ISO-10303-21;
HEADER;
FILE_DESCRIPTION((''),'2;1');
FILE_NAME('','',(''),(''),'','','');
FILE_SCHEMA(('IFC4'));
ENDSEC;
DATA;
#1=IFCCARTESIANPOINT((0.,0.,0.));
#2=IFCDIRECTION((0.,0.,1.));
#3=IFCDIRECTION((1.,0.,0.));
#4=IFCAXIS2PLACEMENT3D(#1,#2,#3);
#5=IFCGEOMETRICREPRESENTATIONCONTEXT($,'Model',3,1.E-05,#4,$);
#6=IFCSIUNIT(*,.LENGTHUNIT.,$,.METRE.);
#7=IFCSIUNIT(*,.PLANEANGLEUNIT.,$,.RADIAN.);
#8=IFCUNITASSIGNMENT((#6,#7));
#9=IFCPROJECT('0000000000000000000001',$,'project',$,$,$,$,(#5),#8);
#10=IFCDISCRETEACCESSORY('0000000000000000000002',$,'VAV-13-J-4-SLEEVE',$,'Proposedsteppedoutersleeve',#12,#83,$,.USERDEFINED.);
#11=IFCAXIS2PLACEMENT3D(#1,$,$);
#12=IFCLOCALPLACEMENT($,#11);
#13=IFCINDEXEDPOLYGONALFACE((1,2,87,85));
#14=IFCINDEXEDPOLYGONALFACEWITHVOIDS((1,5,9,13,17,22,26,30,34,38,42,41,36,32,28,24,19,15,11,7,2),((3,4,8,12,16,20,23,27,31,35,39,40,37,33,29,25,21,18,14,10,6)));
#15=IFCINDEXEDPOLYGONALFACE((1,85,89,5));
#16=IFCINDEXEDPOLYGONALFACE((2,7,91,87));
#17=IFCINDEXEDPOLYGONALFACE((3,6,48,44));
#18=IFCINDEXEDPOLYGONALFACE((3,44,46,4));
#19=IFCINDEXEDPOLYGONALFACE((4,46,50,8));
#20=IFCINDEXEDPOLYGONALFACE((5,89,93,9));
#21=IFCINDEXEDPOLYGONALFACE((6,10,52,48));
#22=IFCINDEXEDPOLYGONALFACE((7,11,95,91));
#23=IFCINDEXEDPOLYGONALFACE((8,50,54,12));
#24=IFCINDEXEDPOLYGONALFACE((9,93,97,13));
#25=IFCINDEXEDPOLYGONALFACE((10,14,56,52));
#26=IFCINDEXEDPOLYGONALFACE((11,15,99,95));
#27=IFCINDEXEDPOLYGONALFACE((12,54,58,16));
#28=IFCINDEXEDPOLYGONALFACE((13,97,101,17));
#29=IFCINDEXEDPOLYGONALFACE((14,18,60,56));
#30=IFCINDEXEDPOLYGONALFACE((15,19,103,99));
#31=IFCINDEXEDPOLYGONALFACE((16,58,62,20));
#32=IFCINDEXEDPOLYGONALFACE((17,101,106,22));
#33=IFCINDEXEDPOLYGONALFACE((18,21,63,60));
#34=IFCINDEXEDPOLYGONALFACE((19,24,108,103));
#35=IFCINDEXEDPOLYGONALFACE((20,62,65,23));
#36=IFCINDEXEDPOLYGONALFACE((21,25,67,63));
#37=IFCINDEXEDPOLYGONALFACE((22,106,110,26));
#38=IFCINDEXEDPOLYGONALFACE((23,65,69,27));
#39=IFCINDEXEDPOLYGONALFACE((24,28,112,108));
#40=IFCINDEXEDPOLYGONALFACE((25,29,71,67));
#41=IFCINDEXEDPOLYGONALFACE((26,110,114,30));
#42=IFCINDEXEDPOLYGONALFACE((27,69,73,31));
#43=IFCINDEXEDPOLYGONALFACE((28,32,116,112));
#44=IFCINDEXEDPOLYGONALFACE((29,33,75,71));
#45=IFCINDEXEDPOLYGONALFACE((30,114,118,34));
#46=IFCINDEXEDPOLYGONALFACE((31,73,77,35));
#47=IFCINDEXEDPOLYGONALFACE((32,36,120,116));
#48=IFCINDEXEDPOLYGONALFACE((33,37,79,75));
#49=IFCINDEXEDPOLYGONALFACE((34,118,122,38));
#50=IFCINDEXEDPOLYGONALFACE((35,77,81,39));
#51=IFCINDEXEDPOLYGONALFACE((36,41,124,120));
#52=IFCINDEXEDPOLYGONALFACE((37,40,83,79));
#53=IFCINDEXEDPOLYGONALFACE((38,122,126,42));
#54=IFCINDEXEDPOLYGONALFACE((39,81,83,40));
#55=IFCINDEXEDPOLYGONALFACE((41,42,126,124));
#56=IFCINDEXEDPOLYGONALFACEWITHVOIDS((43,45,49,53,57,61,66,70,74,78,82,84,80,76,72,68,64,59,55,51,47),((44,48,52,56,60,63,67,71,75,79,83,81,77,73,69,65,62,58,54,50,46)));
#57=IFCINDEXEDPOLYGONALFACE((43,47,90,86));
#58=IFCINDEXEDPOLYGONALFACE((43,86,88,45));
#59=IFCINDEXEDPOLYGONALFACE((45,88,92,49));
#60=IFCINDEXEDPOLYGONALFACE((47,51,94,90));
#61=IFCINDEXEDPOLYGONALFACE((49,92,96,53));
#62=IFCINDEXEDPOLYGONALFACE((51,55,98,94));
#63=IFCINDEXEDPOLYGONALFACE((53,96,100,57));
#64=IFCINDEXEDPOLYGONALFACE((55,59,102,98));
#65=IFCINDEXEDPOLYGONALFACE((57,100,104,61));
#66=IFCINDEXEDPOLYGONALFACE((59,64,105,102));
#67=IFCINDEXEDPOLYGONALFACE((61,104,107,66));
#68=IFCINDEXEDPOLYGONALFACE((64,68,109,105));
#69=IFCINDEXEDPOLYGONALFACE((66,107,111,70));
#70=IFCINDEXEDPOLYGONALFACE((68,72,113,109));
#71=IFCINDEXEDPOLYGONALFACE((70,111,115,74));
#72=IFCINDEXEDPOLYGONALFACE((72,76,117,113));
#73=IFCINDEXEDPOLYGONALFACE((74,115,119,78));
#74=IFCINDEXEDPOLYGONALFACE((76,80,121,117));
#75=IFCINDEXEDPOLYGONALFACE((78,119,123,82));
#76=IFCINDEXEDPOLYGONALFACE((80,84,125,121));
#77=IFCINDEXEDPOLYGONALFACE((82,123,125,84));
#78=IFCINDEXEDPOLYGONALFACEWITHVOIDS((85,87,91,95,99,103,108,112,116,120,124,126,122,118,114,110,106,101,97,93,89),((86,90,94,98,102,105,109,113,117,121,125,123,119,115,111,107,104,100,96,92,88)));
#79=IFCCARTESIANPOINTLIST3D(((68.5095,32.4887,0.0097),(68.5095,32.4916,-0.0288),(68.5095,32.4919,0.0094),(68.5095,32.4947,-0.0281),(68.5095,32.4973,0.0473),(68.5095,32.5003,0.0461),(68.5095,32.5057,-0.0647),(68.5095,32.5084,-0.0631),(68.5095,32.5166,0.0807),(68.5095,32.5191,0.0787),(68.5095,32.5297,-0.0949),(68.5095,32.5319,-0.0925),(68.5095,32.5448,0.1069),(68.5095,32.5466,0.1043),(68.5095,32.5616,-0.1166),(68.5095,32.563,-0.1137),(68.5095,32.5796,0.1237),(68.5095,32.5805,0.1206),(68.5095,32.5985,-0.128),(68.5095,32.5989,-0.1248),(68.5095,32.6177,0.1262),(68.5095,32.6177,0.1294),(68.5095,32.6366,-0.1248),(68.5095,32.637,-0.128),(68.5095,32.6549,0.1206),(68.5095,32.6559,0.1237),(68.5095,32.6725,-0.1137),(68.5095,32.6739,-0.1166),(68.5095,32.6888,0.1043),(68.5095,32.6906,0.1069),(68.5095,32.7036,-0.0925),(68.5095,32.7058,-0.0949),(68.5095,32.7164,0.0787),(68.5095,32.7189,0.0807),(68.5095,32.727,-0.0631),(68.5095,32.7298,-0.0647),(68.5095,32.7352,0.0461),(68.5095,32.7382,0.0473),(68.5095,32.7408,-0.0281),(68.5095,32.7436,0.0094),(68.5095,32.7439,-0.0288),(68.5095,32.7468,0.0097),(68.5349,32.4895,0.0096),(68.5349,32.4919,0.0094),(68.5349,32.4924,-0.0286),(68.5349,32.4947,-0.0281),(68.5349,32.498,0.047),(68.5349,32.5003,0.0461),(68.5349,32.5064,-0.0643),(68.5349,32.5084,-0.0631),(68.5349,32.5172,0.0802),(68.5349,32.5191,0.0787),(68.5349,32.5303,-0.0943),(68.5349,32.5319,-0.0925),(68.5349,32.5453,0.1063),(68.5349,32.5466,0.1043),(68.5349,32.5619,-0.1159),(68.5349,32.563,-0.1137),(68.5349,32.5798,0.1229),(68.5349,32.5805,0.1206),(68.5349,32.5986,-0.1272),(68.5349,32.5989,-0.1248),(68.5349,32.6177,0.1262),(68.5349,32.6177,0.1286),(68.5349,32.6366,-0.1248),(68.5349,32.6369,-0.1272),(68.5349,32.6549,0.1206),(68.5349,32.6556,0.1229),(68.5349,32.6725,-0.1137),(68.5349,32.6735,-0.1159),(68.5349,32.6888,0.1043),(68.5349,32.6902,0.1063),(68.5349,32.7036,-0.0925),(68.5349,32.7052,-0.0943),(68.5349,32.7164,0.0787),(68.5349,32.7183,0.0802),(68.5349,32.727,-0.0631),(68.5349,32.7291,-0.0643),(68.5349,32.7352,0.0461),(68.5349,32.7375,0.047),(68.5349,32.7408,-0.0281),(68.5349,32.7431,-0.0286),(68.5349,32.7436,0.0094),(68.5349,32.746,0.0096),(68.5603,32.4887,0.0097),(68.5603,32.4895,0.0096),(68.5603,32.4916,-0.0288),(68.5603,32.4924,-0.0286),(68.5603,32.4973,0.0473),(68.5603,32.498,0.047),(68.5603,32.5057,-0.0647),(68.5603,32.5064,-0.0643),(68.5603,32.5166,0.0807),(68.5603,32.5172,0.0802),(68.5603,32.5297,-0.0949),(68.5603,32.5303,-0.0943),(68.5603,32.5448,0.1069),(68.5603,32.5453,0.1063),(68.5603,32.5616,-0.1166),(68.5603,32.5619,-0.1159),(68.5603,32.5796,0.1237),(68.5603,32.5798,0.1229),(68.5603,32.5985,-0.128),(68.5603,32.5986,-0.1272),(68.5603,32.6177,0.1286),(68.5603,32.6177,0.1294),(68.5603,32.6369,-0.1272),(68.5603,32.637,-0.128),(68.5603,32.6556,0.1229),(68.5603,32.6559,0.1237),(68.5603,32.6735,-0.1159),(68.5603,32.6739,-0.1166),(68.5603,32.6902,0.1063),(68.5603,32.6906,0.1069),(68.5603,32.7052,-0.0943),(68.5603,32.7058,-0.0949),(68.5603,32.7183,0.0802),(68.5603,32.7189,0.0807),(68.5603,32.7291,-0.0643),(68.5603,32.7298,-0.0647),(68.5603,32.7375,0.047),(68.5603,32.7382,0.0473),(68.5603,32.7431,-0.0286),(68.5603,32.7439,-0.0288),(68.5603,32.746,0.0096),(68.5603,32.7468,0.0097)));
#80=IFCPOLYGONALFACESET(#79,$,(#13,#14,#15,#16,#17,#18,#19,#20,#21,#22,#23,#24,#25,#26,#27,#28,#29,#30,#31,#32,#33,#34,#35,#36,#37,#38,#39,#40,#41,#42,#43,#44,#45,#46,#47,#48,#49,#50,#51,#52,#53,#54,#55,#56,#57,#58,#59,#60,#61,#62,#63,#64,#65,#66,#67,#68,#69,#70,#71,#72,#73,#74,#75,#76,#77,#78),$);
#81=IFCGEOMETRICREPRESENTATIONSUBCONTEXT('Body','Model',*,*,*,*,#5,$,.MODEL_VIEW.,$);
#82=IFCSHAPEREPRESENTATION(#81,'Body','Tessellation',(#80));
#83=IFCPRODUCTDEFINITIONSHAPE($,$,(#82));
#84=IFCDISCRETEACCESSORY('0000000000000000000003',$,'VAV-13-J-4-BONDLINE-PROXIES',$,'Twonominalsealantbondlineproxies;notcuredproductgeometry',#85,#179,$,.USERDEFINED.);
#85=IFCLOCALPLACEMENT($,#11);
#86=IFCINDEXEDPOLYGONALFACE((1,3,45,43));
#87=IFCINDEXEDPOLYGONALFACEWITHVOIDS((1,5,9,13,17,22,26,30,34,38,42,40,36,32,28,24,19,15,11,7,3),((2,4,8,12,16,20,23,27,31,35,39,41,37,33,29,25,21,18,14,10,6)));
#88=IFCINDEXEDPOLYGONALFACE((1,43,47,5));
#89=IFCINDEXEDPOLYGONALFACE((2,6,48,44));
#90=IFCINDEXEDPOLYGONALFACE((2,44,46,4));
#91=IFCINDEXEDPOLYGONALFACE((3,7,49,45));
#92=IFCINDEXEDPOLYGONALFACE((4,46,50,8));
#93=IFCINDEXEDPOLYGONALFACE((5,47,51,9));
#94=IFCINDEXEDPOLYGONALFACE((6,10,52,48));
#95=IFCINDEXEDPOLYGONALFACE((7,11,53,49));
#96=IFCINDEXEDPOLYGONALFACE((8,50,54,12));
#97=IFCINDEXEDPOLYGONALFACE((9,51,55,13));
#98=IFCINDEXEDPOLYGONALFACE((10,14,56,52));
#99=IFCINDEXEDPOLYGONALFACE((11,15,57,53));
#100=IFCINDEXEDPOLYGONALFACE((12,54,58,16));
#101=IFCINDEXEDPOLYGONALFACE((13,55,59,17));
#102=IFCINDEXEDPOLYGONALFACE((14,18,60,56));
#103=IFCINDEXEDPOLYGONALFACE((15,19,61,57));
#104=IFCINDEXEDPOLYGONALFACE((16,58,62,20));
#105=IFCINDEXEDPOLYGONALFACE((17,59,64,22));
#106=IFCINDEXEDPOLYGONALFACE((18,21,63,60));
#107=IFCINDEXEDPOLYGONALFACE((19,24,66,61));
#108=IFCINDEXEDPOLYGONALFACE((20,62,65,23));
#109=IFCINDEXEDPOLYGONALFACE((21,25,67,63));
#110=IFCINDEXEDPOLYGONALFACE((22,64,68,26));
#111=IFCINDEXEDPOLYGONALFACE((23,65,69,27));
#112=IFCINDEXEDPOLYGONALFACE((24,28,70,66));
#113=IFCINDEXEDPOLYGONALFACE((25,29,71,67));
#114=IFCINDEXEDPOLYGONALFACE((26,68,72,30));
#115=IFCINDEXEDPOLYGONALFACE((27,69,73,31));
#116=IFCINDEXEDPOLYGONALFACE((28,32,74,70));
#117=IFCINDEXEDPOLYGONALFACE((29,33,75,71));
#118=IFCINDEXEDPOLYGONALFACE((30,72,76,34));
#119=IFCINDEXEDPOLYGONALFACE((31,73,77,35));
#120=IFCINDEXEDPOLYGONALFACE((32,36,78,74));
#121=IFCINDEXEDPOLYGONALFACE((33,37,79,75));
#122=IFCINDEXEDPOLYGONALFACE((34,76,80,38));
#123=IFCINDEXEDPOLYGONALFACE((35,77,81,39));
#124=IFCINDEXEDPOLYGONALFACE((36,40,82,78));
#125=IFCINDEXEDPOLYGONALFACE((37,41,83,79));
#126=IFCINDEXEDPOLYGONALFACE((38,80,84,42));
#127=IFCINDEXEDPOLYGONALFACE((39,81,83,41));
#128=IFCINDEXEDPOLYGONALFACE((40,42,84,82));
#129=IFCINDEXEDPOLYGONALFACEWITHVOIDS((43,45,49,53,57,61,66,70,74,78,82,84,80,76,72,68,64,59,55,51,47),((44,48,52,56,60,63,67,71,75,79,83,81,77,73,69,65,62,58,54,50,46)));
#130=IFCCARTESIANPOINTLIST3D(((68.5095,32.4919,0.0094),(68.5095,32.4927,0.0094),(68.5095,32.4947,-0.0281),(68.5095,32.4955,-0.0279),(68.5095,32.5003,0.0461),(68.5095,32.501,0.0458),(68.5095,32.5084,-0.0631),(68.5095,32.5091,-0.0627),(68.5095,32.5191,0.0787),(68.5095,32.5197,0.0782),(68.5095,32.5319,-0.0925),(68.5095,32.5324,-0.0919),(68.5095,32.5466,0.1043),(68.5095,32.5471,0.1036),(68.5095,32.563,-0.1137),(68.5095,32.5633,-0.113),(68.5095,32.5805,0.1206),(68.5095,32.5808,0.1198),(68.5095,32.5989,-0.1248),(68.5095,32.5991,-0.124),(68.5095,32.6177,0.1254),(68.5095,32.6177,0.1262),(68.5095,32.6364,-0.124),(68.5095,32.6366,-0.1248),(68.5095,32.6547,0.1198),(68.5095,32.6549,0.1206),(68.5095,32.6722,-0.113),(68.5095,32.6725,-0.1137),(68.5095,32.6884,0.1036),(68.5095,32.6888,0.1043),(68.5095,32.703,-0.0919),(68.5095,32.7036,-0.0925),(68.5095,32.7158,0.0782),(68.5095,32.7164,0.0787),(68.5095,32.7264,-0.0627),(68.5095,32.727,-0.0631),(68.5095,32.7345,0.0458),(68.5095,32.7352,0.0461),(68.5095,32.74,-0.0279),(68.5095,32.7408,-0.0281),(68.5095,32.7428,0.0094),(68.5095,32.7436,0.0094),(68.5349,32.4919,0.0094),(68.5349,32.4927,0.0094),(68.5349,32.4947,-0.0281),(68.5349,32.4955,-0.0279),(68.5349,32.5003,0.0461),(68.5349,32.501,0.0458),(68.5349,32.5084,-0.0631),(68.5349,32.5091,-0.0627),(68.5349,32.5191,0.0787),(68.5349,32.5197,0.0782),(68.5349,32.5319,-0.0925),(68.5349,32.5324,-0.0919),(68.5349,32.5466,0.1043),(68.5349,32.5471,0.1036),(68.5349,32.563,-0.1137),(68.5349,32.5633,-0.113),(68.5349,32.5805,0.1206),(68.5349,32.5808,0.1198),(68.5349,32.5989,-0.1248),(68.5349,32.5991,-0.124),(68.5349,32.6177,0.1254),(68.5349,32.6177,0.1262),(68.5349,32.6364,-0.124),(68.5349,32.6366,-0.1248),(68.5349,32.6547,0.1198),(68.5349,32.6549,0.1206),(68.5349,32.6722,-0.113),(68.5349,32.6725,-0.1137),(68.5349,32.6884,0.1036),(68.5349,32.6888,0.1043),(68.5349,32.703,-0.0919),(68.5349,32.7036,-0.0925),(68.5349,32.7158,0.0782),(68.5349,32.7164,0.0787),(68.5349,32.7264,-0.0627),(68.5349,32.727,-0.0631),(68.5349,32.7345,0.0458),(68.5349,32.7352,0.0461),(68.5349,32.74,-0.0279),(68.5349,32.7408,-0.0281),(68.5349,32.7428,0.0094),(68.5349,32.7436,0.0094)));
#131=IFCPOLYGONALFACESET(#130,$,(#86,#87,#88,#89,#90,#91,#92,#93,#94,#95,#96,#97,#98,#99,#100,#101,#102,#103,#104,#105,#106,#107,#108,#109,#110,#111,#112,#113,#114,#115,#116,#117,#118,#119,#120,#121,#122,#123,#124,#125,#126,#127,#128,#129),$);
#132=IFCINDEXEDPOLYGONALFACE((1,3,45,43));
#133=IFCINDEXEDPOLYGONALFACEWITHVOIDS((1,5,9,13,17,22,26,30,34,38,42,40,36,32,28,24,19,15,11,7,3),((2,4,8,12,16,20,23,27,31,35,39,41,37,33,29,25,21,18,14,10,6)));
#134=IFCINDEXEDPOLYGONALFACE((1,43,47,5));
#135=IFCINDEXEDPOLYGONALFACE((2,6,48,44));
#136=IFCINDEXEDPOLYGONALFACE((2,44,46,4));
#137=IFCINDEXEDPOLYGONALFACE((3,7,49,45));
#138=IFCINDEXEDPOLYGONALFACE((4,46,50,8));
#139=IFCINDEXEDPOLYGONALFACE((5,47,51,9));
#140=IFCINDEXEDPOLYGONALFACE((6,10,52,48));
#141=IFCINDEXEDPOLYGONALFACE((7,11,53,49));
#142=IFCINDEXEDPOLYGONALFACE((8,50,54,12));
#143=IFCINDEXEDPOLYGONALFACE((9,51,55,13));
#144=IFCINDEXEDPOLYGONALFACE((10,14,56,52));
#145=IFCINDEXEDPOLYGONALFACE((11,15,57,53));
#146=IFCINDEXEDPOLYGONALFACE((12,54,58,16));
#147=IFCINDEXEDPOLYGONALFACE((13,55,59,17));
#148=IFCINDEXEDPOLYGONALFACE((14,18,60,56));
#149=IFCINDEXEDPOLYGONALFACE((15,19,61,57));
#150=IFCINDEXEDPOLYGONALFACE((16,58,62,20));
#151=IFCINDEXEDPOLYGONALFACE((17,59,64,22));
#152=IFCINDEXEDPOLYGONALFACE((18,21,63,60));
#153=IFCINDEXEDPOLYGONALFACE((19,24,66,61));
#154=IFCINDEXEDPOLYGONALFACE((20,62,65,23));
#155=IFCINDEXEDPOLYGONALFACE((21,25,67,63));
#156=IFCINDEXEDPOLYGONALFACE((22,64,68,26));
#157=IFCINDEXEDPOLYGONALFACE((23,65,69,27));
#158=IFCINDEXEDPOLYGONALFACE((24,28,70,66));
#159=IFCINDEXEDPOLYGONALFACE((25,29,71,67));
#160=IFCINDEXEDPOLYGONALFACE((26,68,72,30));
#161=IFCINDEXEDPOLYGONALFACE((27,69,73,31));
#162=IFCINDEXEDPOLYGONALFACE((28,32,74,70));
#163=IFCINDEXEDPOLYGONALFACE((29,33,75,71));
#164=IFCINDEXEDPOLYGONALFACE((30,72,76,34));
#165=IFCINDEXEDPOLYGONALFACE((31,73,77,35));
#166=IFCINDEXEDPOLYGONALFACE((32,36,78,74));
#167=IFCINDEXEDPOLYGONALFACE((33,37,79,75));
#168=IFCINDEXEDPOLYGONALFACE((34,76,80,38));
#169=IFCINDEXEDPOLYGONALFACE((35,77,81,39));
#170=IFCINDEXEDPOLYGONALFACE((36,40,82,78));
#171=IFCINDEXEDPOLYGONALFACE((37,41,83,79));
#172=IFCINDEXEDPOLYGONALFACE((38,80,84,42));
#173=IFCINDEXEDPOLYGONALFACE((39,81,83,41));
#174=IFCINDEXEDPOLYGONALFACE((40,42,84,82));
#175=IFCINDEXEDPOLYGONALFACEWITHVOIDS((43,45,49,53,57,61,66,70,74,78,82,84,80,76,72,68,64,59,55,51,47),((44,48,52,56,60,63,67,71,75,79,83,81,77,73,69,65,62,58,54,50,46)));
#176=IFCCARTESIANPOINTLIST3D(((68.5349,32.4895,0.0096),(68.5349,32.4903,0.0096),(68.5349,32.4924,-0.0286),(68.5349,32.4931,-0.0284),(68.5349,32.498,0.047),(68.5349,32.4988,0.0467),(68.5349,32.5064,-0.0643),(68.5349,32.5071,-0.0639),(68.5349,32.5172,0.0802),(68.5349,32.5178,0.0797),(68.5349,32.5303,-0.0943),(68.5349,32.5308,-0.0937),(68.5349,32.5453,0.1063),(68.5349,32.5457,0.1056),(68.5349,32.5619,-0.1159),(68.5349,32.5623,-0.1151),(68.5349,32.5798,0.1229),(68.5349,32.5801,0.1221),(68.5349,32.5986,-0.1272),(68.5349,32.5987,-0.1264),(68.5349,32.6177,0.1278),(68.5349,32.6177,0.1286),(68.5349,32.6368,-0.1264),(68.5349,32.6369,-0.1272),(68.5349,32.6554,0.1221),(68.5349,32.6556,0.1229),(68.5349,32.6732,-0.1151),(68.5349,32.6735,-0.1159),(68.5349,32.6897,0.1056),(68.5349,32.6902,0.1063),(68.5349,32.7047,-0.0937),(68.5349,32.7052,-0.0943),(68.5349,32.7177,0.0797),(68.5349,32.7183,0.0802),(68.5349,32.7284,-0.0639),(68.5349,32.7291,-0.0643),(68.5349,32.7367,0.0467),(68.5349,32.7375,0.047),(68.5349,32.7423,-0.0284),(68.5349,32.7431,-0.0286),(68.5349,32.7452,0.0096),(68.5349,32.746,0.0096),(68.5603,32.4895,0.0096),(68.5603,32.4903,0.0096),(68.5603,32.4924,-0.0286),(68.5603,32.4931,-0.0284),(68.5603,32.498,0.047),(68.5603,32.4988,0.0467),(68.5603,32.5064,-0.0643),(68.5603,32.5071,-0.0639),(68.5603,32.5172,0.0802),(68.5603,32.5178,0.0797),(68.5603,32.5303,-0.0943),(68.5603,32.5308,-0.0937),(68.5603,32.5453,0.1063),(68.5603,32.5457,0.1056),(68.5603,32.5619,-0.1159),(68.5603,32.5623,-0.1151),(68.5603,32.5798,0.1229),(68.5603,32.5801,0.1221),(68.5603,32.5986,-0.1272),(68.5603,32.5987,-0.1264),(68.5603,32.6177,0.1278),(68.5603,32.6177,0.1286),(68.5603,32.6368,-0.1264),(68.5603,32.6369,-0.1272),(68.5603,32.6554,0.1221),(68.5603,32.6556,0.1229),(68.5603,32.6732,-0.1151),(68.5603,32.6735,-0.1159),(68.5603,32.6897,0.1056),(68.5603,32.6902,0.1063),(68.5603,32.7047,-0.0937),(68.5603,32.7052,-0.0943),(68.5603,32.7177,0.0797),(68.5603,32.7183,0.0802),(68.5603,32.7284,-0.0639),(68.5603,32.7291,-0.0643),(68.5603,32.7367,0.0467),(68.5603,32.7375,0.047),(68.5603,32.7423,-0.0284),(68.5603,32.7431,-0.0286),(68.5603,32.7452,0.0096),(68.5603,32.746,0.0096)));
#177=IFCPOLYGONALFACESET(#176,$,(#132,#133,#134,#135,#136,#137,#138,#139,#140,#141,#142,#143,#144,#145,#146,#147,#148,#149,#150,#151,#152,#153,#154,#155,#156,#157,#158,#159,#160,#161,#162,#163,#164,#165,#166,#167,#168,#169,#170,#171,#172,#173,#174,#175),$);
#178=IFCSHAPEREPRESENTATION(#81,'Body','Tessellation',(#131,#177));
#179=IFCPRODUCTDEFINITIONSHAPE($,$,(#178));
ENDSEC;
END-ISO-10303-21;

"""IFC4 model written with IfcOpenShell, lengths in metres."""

from ifc_helpers import new_model, entity, si_unit, frame, origin_with_axes, place, context, subcontext, project, element, save


model = new_model("IFC4")

# Units and contexts
model_context = context("Model", 3, precision=1e-05, world=origin_with_axes())
body_context = subcontext(model_context, "Body", "Model", "MODEL_VIEW")
ifc_project = project(units=[si_unit("LENGTHUNIT", "METRE"), si_unit("PLANEANGLEUNIT", "RADIAN")], contexts=[model_context])

# Discrete accessories
discrete_accessory_1_placement = place(None, frame((68.5349, 32.6177, 0.0), z_axis=(0.0, 1.0, 0.0), x_axis=(0.0, 0.0, 1.0)))
element("IfcDiscreteAccessory", 1, at=discrete_accessory_1_placement, Name="VAV-13-J-4-SLEEVE", ObjectType="Proposedsteppedoutersleeve", PredefinedType="USERDEFINED", context=body_context, shape_type="SweptSolid", body=[
    entity("IfcRevolvedAreaSolid", entity("IfcArbitraryClosedProfileDef", "AREA", None, entity("IfcPolyline", [entity("IfcCartesianPoint", [0.1262, -0.0254]), entity("IfcCartesianPoint", [0.1294, -0.0254]), entity("IfcCartesianPoint", [0.1294, 0.0254]), entity("IfcCartesianPoint", [0.1286, 0.0254]), entity("IfcCartesianPoint", [0.1286, 0.0]), entity("IfcCartesianPoint", [0.1262, 0.0]), entity("IfcCartesianPoint", [0.1262, -0.0254])])), entity("IfcAxis2Placement3D", entity("IfcCartesianPoint", [0.0, 0.0, 0.0])), entity("IfcAxis1Placement", entity("IfcCartesianPoint", [0.0, 0.0, 0.0]), entity("IfcDirection", [0.0, 1.0, 0.0])), 6.283185),
])
discrete_accessory_2_placement = place(None, frame((68.5349, 32.6177, 0.0), z_axis=(0.0, 1.0, 0.0), x_axis=(0.0, 0.0, 1.0)))
element("IfcDiscreteAccessory", 2, at=discrete_accessory_2_placement, Name="VAV-13-J-4-BONDLINE-PROXIES", ObjectType="Twonominalsealantbondlineproxies;notcuredproductgeometry", PredefinedType="USERDEFINED", context=body_context, shape_type="SweptSolid", body=[
    entity("IfcRevolvedAreaSolid", entity("IfcArbitraryClosedProfileDef", "AREA", None, entity("IfcPolyline", [entity("IfcCartesianPoint", [0.1254, -0.0254]), entity("IfcCartesianPoint", [0.1262, -0.0254]), entity("IfcCartesianPoint", [0.1262, 0.0]), entity("IfcCartesianPoint", [0.1254, 0.0]), entity("IfcCartesianPoint", [0.1254, -0.0254])])), entity("IfcAxis2Placement3D", entity("IfcCartesianPoint", [0.0, 0.0, 0.0])), entity("IfcAxis1Placement", entity("IfcCartesianPoint", [0.0, 0.0, 0.0]), entity("IfcDirection", [0.0, 1.0, 0.0])), 6.283185),
    entity("IfcRevolvedAreaSolid", entity("IfcArbitraryClosedProfileDef", "AREA", None, entity("IfcPolyline", [entity("IfcCartesianPoint", [0.1278, 0.0]), entity("IfcCartesianPoint", [0.1286, 0.0]), entity("IfcCartesianPoint", [0.1286, 0.0254]), entity("IfcCartesianPoint", [0.1278, 0.0254]), entity("IfcCartesianPoint", [0.1278, 0.0])])), entity("IfcAxis2Placement3D", entity("IfcCartesianPoint", [0.0, 0.0, 0.0])), entity("IfcAxis1Placement", entity("IfcCartesianPoint", [0.0, 0.0, 0.0]), entity("IfcDirection", [0.0, 1.0, 0.0])), 6.283185),
])

save(model, "model.ifc")
